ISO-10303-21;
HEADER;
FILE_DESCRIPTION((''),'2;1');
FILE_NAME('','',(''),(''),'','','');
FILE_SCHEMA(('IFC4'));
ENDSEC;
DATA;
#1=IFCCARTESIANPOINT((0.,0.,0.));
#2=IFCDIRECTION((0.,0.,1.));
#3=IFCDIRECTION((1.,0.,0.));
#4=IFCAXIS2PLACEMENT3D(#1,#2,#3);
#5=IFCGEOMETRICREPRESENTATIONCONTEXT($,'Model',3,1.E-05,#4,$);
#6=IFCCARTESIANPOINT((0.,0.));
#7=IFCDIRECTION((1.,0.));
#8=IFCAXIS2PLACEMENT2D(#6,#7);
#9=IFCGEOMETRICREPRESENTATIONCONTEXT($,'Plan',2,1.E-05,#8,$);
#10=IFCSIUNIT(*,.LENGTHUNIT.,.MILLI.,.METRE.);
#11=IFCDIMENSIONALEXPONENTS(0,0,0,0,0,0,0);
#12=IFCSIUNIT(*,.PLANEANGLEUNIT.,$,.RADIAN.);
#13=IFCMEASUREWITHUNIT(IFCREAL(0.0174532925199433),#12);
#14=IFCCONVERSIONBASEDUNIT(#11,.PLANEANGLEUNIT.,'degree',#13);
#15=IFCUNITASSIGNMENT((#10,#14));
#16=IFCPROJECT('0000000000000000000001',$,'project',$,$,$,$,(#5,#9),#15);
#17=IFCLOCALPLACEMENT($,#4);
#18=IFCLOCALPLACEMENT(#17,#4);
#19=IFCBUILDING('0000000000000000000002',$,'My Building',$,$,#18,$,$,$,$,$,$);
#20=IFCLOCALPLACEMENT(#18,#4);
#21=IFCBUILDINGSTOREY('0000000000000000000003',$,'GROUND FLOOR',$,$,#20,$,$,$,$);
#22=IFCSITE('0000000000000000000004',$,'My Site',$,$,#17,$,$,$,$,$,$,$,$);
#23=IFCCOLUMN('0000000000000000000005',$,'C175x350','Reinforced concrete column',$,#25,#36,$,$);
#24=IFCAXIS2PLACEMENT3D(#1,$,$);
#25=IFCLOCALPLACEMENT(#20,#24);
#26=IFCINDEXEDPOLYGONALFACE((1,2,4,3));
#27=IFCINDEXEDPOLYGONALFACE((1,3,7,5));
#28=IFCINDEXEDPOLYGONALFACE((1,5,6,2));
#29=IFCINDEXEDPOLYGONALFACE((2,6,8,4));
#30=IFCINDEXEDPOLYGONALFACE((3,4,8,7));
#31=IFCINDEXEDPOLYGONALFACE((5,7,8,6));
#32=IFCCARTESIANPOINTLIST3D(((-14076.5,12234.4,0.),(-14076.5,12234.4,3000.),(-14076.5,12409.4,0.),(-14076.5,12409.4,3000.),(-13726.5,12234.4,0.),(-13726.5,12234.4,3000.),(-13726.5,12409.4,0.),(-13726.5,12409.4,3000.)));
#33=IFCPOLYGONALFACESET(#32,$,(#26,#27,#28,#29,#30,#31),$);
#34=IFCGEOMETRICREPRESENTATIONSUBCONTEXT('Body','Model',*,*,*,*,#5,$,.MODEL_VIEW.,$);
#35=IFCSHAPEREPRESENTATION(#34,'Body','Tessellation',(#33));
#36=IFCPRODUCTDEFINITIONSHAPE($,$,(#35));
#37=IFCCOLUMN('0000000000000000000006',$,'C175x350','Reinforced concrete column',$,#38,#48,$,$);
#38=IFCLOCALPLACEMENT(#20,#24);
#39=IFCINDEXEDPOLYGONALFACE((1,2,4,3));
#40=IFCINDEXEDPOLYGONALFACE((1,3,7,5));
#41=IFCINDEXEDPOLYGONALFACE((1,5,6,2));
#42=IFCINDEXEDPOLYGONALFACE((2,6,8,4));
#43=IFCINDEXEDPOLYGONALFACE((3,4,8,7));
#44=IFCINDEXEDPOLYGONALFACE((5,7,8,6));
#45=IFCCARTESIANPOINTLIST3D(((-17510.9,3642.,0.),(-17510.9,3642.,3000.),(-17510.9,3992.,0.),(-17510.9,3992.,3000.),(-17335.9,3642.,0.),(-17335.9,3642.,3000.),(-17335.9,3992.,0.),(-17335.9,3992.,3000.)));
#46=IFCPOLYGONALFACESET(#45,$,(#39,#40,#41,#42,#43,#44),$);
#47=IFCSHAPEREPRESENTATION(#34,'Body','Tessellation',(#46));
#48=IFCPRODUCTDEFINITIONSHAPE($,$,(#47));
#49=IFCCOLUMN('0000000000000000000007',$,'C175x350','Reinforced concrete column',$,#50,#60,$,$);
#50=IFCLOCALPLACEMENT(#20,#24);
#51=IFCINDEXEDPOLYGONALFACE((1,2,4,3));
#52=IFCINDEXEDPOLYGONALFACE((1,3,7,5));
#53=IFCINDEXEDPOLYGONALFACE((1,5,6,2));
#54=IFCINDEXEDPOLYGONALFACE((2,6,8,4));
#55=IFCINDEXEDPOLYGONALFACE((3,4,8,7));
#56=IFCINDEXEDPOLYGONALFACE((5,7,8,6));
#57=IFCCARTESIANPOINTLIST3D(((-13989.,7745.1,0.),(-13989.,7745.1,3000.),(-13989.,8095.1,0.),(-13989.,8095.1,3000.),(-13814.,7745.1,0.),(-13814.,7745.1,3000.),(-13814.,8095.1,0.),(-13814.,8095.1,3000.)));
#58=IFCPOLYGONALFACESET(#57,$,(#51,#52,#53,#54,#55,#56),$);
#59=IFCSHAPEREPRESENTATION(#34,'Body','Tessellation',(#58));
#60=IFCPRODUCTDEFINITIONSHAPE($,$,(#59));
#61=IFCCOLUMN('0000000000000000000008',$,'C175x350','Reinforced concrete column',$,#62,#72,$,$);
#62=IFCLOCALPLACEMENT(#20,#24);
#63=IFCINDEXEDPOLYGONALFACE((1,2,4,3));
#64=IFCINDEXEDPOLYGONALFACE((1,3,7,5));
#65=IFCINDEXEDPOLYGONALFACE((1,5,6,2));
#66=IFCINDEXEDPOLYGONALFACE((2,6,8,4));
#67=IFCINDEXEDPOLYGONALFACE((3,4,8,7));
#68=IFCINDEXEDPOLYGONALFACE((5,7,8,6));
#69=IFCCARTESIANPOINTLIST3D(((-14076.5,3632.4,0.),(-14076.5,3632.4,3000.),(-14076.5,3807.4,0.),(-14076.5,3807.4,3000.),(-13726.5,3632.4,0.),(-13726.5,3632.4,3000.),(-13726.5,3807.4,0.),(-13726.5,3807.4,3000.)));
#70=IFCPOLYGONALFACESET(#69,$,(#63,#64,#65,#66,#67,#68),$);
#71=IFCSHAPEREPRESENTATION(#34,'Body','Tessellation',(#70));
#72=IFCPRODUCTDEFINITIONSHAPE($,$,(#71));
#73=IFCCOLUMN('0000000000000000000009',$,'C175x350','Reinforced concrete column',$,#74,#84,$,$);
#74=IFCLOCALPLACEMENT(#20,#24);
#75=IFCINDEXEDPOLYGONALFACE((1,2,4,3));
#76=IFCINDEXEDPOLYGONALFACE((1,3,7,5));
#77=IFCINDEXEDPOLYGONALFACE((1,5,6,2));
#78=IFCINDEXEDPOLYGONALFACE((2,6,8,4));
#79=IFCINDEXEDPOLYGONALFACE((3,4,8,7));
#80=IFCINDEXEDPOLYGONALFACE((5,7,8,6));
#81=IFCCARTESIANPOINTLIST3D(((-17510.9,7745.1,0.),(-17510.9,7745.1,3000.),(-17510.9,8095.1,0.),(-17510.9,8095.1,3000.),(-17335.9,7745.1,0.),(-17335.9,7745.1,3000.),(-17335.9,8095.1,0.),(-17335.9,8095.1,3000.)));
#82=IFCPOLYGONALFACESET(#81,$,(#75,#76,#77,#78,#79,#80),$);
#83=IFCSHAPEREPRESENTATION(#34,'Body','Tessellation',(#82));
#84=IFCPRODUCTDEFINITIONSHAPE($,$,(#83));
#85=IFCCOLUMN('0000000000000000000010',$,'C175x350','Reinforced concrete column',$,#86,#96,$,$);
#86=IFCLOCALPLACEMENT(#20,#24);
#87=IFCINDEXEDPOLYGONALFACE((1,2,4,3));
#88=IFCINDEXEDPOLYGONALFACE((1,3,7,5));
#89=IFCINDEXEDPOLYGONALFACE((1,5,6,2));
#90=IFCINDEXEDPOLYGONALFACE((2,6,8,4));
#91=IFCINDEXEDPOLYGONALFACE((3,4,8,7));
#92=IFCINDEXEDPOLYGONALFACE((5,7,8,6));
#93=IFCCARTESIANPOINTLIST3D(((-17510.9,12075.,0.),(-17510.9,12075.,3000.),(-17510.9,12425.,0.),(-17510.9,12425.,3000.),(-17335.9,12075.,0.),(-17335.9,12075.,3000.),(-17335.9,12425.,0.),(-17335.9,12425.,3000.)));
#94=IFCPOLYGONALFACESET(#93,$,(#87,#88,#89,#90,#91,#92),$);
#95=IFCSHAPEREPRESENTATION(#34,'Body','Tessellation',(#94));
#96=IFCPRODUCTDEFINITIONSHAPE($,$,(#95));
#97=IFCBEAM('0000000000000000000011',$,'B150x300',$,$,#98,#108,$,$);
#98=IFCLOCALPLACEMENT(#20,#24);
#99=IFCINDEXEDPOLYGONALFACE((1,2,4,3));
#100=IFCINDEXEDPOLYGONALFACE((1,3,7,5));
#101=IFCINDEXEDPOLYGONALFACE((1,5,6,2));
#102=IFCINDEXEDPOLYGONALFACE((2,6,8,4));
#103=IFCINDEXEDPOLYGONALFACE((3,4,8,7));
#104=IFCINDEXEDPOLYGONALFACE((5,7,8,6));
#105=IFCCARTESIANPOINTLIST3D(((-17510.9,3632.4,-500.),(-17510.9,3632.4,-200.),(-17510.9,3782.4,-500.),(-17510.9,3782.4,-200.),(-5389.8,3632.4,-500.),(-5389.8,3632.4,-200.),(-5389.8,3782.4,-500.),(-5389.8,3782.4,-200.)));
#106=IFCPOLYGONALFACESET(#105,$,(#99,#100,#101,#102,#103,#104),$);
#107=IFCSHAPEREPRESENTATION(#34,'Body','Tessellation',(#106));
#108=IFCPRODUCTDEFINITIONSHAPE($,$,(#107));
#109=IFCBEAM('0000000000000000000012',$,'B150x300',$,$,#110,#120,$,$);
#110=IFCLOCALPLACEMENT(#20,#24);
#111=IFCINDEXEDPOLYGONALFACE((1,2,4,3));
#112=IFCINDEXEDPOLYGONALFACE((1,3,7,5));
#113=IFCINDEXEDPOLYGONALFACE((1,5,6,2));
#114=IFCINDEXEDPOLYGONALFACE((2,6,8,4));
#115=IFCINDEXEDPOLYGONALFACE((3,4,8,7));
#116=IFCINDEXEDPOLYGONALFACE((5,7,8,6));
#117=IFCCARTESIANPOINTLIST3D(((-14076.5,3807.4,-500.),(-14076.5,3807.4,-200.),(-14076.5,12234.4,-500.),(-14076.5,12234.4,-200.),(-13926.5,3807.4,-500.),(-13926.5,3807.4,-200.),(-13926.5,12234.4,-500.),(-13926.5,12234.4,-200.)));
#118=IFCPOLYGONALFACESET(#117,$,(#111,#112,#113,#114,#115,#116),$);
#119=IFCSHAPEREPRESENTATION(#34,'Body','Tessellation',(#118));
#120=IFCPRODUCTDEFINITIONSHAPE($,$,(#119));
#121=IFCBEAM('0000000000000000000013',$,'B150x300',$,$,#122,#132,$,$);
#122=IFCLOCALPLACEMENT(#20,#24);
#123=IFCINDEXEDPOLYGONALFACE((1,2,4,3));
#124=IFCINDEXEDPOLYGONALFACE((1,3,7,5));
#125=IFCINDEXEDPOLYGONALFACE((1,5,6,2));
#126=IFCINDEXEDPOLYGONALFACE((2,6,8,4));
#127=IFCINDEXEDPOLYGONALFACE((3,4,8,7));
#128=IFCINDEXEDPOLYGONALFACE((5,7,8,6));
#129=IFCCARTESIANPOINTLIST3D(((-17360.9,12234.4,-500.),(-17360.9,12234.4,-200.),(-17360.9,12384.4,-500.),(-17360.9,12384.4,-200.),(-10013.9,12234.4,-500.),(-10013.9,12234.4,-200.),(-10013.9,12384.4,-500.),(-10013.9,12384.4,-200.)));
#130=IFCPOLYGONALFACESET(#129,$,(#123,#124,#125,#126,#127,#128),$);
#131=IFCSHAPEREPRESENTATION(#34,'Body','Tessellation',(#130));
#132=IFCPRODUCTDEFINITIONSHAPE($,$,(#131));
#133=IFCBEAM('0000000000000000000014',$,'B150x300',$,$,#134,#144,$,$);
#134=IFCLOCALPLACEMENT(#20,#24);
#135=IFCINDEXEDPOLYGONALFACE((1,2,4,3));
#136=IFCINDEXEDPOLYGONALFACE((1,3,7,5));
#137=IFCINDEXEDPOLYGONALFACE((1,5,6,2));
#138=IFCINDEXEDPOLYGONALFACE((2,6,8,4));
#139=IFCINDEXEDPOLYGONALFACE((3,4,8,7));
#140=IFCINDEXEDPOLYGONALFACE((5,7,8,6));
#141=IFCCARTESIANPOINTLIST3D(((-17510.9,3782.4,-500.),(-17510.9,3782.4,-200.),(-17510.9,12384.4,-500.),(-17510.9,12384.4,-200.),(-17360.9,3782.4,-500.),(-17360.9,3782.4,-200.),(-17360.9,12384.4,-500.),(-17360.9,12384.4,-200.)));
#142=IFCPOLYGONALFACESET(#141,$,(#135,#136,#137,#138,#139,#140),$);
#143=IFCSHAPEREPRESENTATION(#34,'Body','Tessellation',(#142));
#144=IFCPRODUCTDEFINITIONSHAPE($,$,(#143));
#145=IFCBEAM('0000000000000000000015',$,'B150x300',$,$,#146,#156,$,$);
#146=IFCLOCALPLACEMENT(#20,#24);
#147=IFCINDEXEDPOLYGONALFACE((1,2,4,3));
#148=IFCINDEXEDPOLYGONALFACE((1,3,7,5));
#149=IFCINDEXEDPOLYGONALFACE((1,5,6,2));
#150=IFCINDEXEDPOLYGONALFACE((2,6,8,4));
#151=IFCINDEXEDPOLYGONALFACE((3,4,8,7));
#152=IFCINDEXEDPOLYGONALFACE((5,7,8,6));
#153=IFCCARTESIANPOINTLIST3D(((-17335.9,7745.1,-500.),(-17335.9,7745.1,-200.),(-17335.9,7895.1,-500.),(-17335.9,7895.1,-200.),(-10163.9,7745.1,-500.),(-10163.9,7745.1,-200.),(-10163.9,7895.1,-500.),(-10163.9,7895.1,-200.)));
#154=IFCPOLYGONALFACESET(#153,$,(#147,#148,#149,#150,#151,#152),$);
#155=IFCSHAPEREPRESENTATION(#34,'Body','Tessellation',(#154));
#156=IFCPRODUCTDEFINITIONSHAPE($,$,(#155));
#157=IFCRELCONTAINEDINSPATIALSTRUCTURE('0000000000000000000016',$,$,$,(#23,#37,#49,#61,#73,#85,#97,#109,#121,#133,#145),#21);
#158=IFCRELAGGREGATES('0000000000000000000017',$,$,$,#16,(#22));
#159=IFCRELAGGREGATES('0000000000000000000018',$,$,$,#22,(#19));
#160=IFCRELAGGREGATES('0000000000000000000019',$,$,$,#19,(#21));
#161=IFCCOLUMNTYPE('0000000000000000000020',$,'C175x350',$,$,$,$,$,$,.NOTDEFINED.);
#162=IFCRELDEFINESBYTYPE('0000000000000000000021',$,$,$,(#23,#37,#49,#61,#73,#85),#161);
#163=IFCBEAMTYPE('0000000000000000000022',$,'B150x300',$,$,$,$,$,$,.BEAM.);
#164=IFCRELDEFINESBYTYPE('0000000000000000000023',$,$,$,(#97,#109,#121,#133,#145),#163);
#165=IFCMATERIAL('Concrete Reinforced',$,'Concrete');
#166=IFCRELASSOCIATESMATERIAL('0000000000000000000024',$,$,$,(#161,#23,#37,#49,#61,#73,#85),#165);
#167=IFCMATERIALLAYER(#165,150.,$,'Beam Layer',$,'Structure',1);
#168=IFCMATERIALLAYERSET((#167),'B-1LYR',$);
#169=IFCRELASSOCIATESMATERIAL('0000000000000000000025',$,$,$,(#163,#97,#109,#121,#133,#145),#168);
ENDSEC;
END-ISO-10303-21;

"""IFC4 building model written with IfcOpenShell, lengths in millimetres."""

from ifc_helpers import new_model, entity, si_unit, converted_unit, frame, origin_with_axes, origin_2d_with_axis, place, context, subcontext, project, spatial, indexed_curve, rectangle, outline, extrude, material, layer, layer_set, layer_usage, material_profile, profile_set, profile_usage, type_object, element, save


model = new_model("IFC4")

# Units and contexts
model_context = context("Model", 3, precision=1e-05, world=origin_with_axes())
plan_context = context("Plan", 2, precision=1e-05, world=origin_2d_with_axis())
body_context_1 = subcontext(model_context, "Body", "Model", "MODEL_VIEW")
ifc_project = project(units=[si_unit("LENGTHUNIT", "METRE", prefix="MILLI"), converted_unit("PLANEANGLEUNIT", "degree", entity("IfcReal", 0.0174532925199433), si_unit("PLANEANGLEUNIT", "RADIAN"), dimensions=[0, 0, 0, 0, 0, 0, 0])], contexts=[model_context, plan_context])

# Site, building, storey
site_placement = place(None, origin_with_axes())
site = spatial("IfcSite", under=ifc_project, at=site_placement, Name="My Site")
building_placement = place(site_placement, origin_with_axes())
building = spatial("IfcBuilding", under=site, at=building_placement, Name="My Building")
storey_placement = place(building_placement, origin_with_axes())
storey = spatial("IfcBuildingStorey", under=building, at=storey_placement, Name="GROUND FLOOR")

# Columns
ifc_material_1 = material(Name="Concrete Reinforced", Category="Concrete")
ifc_material_profile = material_profile(ifc_material_1, rectangle(XDim=175.0, YDim=350.0), Name="R. C. Layer", Category="Structure", Priority=1)
ifc_profile_set = profile_set([ifc_material_profile], Name="COL_1LYR")
ifc_profile_usage_1 = profile_usage(ifc_profile_set, cardinal=5)
column_type = type_object("IfcColumnType", Name="C175x350", PredefinedType="NOTDEFINED", material=ifc_profile_set)
column_1_placement = place(storey_placement, frame((-13901.5, 12321.9, 0.0), z_axis=(0.0, 0.0, 1.0), x_axis=(0.0, -1.0, 0.0)))
element("IfcColumn", 1, at=column_1_placement, inside=storey, type_object=column_type, material=ifc_profile_usage_1, Name="C175x350", Description="Reinforced concrete column", context=body_context_1, shape_type="SweptSolid", body=[
    extrude(rectangle(XDim=175.0, YDim=350.0), origin_with_axes(), (0.0, 0.0, 1.0), 3000.0),
])
ifc_profile_usage_2 = profile_usage(ifc_profile_set, cardinal=5)
column_2_placement = place(storey_placement, frame((-17423.4, 3817.0, 0.0), z_axis=(0.0, 0.0, 1.0), x_axis=(1.0, 0.0, 0.0)))
element("IfcColumn", 2, at=column_2_placement, inside=storey, type_object=column_type, material=ifc_profile_usage_2, Name="C175x350", Description="Reinforced concrete column", context=body_context_1, shape_type="SweptSolid", body=[
    extrude(rectangle(XDim=175.0, YDim=350.0), origin_with_axes(), (0.0, 0.0, 1.0), 3000.0),
])
ifc_profile_usage_3 = profile_usage(ifc_profile_set, cardinal=5)
column_3_placement = place(storey_placement, frame((-13901.5, 7920.1, 0.0), z_axis=(0.0, 0.0, 1.0), x_axis=(1.0, 0.0, 0.0)))
element("IfcColumn", 3, at=column_3_placement, inside=storey, type_object=column_type, material=ifc_profile_usage_3, Name="C175x350", Description="Reinforced concrete column", context=body_context_1, shape_type="SweptSolid", body=[
    extrude(rectangle(XDim=175.0, YDim=350.0), origin_with_axes(), (0.0, 0.0, 1.0), 3000.0),
])
ifc_profile_usage_4 = profile_usage(ifc_profile_set, cardinal=5)
column_4_placement = place(storey_placement, frame((-13901.5, 3719.9, 0.0), z_axis=(0.0, 0.0, 1.0), x_axis=(0.0, -1.0, 0.0)))
element("IfcColumn", 4, at=column_4_placement, inside=storey, type_object=column_type, material=ifc_profile_usage_4, Name="C175x350", Description="Reinforced concrete column", context=body_context_1, shape_type="SweptSolid", body=[
    extrude(rectangle(XDim=175.0, YDim=350.0), origin_with_axes(), (0.0, 0.0, 1.0), 3000.0),
])
ifc_profile_usage_5 = profile_usage(ifc_profile_set, cardinal=5)
column_5_placement = place(storey_placement, frame((-17423.4, 7920.1, 0.0), z_axis=(0.0, 0.0, 1.0), x_axis=(1.0, 0.0, 0.0)))
element("IfcColumn", 5, at=column_5_placement, inside=storey, type_object=column_type, material=ifc_profile_usage_5, Name="C175x350", Description="Reinforced concrete column", context=body_context_1, shape_type="SweptSolid", body=[
    extrude(rectangle(XDim=175.0, YDim=350.0), origin_with_axes(), (0.0, 0.0, 1.0), 3000.0),
])
ifc_profile_usage_6 = profile_usage(ifc_profile_set, cardinal=5)
column_6_placement = place(storey_placement, frame((-17423.4, 12250.0, 0.0), z_axis=(0.0, 0.0, 1.0), x_axis=(1.0, 0.0, 0.0)))
element("IfcColumn", 6, at=column_6_placement, inside=storey, type_object=column_type, material=ifc_profile_usage_6, Name="C175x350", Description="Reinforced concrete column", context=body_context_1, shape_type="SweptSolid", body=[
    extrude(rectangle(XDim=175.0, YDim=350.0), origin_with_axes(), (0.0, 0.0, 1.0), 3000.0),
])

# Beams
ifc_layer_1 = layer(ifc_material_1, 150.0, Name="Beam Layer", Category="Structure", Priority=1)
ifc_layer_set_1 = layer_set([ifc_layer_1], Name="B-1LYR")
ifc_layer_usage_1 = layer_usage(ifc_layer_set_1, "AXIS2", "POSITIVE", 0.0)
beam_type = type_object("IfcBeamType", Name="B150x300", PredefinedType="BEAM", material=ifc_layer_set_1)
beam_1_placement = place(storey_placement, frame((-17510.9, 3632.4, -500.0), z_axis=(0.0, 0.0, 1.0), x_axis=(1.0, 0.0, 0.0)))
element("IfcBeam", 7, at=beam_1_placement, inside=storey, type_object=beam_type, material=ifc_layer_usage_1, Name="B150x300", context=body_context_1, shape_type="SweptSolid", body=[
    extrude(outline(indexed_curve([(0.0, 0.0), (0.0, 150.0), (12121.1, 150.0), (12121.1, 0.0), (0.0, 0.0)], self_intersect=False)), origin_with_axes(), (0.0, 0.0, 1.0), 300.0),
])
ifc_layer_usage_2 = layer_usage(ifc_layer_set_1, "AXIS2", "POSITIVE", 0.0)
beam_2_placement = place(storey_placement, frame((-14076.5, 12234.4, -500.0), z_axis=(0.0, 0.0, 1.0), x_axis=(0.0, -1.0, 0.0)))
element("IfcBeam", 8, at=beam_2_placement, inside=storey, type_object=beam_type, material=ifc_layer_usage_2, Name="B150x300", context=body_context_1, shape_type="SweptSolid", body=[
    extrude(outline(indexed_curve([(0.0, 0.0), (0.0, 150.0), (8427.0, 150.0), (8427.0, 0.0), (0.0, 0.0)], self_intersect=False)), origin_with_axes(), (0.0, 0.0, 1.0), 300.0),
])
ifc_layer_usage_3 = layer_usage(ifc_layer_set_1, "AXIS2", "POSITIVE", 0.0)
beam_3_placement = place(storey_placement, frame((-17360.9, 12234.4, -500.0), z_axis=(0.0, 0.0, 1.0), x_axis=(1.0, 0.0, 0.0)))
element("IfcBeam", 9, at=beam_3_placement, inside=storey, type_object=beam_type, material=ifc_layer_usage_3, Name="B150x300", context=body_context_1, shape_type="SweptSolid", body=[
    extrude(outline(indexed_curve([(0.0, 0.0), (0.0, 150.0), (7347.0, 150.0), (7347.0, 0.0), (0.0, 0.0)], self_intersect=False)), origin_with_axes(), (0.0, 0.0, 1.0), 300.0),
])
ifc_layer_usage_4 = layer_usage(ifc_layer_set_1, "AXIS2", "POSITIVE", 0.0)
beam_4_placement = place(storey_placement, frame((-17510.9, 12384.4, -500.0), z_axis=(0.0, 0.0, 1.0), x_axis=(0.0, -1.0, 0.0)))
element("IfcBeam", 10, at=beam_4_placement, inside=storey, type_object=beam_type, material=ifc_layer_usage_4, Name="B150x300", context=body_context_1, shape_type="SweptSolid", body=[
    extrude(outline(indexed_curve([(0.0, 0.0), (0.0, 150.0), (8602.0, 150.0), (8602.0, 0.0), (0.0, 0.0)], self_intersect=False)), origin_with_axes(), (0.0, 0.0, 1.0), 300.0),
])
ifc_layer_usage_5 = layer_usage(ifc_layer_set_1, "AXIS2", "POSITIVE", 0.0)
beam_5_placement = place(storey_placement, frame((-17335.9, 7745.1, -500.0), z_axis=(0.0, 0.0, 1.0), x_axis=(1.0, 0.0, 0.0)))
element("IfcBeam", 11, at=beam_5_placement, inside=storey, type_object=beam_type, material=ifc_layer_usage_5, Name="B150x300", context=body_context_1, shape_type="SweptSolid", body=[
    extrude(outline(indexed_curve([(0.0, 0.0), (0.0, 150.0), (7172.0, 150.0), (7172.0, 0.0), (0.0, 0.0)], self_intersect=False)), origin_with_axes(), (0.0, 0.0, 1.0), 300.0),
])

save(model, "model.ifc")
